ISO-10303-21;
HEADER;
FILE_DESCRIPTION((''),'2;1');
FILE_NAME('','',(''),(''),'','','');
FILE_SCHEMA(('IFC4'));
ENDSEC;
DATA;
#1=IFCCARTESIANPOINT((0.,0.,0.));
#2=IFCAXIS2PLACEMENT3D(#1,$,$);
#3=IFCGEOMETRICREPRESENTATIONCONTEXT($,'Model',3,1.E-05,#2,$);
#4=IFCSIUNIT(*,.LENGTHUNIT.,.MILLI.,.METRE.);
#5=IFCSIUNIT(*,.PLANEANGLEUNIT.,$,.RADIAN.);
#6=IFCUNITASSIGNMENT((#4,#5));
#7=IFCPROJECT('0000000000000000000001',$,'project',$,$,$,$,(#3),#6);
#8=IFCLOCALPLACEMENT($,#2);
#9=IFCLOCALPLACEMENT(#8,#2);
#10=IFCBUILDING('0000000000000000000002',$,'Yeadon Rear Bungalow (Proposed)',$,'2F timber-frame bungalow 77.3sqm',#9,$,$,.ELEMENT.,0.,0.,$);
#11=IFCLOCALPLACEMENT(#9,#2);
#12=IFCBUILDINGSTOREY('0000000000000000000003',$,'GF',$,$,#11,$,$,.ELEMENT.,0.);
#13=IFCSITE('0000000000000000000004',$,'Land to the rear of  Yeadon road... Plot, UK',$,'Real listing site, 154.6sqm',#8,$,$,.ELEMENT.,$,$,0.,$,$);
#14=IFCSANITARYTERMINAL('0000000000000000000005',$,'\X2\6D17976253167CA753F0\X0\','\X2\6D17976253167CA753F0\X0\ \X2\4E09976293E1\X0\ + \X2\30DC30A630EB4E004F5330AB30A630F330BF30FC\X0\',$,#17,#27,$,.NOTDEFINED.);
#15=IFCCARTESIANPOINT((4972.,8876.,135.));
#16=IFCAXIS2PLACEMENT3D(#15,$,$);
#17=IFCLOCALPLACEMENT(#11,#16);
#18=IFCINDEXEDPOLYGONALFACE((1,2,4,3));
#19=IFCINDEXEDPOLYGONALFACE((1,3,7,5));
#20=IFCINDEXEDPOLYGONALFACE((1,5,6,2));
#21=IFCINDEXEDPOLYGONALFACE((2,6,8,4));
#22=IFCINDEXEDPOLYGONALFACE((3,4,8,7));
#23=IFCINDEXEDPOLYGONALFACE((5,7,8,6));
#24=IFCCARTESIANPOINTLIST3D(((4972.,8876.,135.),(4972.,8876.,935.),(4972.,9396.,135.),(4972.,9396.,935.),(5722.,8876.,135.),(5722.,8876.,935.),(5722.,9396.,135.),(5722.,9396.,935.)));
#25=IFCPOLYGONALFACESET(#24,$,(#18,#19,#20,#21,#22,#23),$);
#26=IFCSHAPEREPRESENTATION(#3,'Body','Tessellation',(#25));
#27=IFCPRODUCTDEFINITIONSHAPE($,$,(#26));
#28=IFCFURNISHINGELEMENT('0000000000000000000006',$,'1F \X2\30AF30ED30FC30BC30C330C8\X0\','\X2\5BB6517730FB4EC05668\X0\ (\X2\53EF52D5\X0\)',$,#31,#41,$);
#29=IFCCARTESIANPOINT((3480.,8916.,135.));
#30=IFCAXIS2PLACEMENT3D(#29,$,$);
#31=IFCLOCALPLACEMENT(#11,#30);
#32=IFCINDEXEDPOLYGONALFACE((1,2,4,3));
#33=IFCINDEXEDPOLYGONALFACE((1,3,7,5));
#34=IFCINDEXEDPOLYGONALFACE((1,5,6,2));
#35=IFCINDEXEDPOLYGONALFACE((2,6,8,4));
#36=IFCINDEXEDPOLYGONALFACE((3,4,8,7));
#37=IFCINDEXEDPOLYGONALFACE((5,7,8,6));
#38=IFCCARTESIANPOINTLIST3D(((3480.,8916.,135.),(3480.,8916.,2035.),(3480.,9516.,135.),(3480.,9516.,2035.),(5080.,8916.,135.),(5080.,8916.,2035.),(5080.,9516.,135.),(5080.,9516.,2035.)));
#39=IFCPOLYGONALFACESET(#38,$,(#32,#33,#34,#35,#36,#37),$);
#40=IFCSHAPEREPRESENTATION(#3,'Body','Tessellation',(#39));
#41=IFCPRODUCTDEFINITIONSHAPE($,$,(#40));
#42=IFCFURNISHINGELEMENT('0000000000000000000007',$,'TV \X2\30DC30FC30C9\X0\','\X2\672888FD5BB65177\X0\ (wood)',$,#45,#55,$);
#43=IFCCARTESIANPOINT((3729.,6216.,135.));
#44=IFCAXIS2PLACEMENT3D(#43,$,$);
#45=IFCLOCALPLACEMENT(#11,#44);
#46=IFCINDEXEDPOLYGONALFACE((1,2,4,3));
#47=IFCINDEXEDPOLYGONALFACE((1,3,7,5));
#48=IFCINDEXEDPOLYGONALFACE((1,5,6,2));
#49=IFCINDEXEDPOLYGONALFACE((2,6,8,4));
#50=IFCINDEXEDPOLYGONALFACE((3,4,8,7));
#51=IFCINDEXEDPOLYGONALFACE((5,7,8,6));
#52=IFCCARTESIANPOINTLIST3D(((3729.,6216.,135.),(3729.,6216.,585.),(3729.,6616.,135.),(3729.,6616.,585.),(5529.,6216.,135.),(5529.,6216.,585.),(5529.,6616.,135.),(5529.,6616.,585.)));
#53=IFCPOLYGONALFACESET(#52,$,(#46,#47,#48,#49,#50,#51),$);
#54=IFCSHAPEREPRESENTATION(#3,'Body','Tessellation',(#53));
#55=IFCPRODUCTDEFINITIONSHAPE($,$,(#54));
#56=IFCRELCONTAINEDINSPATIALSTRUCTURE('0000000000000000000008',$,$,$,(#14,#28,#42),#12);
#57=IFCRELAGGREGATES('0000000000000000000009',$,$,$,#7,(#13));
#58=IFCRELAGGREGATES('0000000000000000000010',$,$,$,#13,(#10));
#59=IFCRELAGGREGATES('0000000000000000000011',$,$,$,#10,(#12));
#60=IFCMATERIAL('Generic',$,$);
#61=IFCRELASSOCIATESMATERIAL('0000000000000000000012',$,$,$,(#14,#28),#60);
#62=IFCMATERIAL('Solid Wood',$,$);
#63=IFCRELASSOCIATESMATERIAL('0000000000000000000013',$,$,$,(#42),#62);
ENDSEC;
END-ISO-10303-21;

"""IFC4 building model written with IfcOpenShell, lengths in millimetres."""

from ifc_helpers import new_model, si_unit, frame, frame_2d, origin, place, context, project, spatial, rectangle, extrude, material, element, save


model = new_model("IFC4")

# Units and contexts
model_context = context("Model", 3, precision=1e-05, world=origin())
ifc_project = project(units=[si_unit("LENGTHUNIT", "METRE", prefix="MILLI"), si_unit("PLANEANGLEUNIT", "RADIAN")], contexts=[model_context])

# Site, building, storey
site_placement = place(None, origin())
site = spatial("IfcSite", under=ifc_project, at=site_placement, Name="Land to the rear of  Yeadon road... Plot, UK", ObjectType="Real listing site, 154.6sqm", CompositionType="ELEMENT", RefElevation=0.0)
building_placement = place(site_placement, origin())
building = spatial("IfcBuilding", under=site, at=building_placement, Name="Yeadon Rear Bungalow (Proposed)", ObjectType="2F timber-frame bungalow 77.3sqm", CompositionType="ELEMENT", ElevationOfRefHeight=0.0, ElevationOfTerrain=0.0)
storey_placement = place(building_placement, origin())
storey = spatial("IfcBuildingStorey", under=building, at=storey_placement, Name="GF", CompositionType="ELEMENT", Elevation=0.0)

# Shared definitions
ifc_material_1 = material(Name="Solid Wood")

# Shared definitions
ifc_material_2 = material(Name="Generic")

# Sanitary terminal
sanitary_terminal_1_placement = place(storey_placement, frame((4972.0, 8876.0, 135.0)))
element("IfcSanitaryTerminal", 1, at=sanitary_terminal_1_placement, inside=storey, material=ifc_material_2, Name="洗面化粧台", Description="洗面化粧台 三面鏡 + ボウル一体カウンター", PredefinedType="NOTDEFINED", context=model_context, shape_type="SweptSolid", body=[
    extrude(rectangle(XDim=750.0, YDim=520.0, at=frame_2d((375.0, 260.0))), frame((4972.0, 8876.0, 135.0)), (0.0, 0.0, 1.0), 800.0),
])

# Furnishing elements
furnishing_1_placement = place(storey_placement, frame((3480.0, 8916.0, 135.0)))
element("IfcFurnishingElement", 2, at=furnishing_1_placement, inside=storey, material=ifc_material_2, Name="1F クローゼット", Description="家具・什器 (可動)", context=model_context, shape_type="SweptSolid", body=[
    extrude(rectangle(XDim=1600.0, YDim=600.0, at=frame_2d((800.0, 300.0))), frame((3480.0, 8916.0, 135.0)), (0.0, 0.0, 1.0), 1900.0),
])
furnishing_2_placement = place(storey_placement, frame((3729.0, 6216.0, 135.0)))
element("IfcFurnishingElement", 3, at=furnishing_2_placement, inside=storey, material=ifc_material_1, Name="TV ボード", Description="木製家具 (wood)", context=model_context, shape_type="SweptSolid", body=[
    extrude(rectangle(XDim=1800.0, YDim=400.0, at=frame_2d((900.0, 200.0))), frame((3729.0, 6216.0, 135.0)), (0.0, 0.0, 1.0), 450.0),
])

save(model, "model.ifc")
